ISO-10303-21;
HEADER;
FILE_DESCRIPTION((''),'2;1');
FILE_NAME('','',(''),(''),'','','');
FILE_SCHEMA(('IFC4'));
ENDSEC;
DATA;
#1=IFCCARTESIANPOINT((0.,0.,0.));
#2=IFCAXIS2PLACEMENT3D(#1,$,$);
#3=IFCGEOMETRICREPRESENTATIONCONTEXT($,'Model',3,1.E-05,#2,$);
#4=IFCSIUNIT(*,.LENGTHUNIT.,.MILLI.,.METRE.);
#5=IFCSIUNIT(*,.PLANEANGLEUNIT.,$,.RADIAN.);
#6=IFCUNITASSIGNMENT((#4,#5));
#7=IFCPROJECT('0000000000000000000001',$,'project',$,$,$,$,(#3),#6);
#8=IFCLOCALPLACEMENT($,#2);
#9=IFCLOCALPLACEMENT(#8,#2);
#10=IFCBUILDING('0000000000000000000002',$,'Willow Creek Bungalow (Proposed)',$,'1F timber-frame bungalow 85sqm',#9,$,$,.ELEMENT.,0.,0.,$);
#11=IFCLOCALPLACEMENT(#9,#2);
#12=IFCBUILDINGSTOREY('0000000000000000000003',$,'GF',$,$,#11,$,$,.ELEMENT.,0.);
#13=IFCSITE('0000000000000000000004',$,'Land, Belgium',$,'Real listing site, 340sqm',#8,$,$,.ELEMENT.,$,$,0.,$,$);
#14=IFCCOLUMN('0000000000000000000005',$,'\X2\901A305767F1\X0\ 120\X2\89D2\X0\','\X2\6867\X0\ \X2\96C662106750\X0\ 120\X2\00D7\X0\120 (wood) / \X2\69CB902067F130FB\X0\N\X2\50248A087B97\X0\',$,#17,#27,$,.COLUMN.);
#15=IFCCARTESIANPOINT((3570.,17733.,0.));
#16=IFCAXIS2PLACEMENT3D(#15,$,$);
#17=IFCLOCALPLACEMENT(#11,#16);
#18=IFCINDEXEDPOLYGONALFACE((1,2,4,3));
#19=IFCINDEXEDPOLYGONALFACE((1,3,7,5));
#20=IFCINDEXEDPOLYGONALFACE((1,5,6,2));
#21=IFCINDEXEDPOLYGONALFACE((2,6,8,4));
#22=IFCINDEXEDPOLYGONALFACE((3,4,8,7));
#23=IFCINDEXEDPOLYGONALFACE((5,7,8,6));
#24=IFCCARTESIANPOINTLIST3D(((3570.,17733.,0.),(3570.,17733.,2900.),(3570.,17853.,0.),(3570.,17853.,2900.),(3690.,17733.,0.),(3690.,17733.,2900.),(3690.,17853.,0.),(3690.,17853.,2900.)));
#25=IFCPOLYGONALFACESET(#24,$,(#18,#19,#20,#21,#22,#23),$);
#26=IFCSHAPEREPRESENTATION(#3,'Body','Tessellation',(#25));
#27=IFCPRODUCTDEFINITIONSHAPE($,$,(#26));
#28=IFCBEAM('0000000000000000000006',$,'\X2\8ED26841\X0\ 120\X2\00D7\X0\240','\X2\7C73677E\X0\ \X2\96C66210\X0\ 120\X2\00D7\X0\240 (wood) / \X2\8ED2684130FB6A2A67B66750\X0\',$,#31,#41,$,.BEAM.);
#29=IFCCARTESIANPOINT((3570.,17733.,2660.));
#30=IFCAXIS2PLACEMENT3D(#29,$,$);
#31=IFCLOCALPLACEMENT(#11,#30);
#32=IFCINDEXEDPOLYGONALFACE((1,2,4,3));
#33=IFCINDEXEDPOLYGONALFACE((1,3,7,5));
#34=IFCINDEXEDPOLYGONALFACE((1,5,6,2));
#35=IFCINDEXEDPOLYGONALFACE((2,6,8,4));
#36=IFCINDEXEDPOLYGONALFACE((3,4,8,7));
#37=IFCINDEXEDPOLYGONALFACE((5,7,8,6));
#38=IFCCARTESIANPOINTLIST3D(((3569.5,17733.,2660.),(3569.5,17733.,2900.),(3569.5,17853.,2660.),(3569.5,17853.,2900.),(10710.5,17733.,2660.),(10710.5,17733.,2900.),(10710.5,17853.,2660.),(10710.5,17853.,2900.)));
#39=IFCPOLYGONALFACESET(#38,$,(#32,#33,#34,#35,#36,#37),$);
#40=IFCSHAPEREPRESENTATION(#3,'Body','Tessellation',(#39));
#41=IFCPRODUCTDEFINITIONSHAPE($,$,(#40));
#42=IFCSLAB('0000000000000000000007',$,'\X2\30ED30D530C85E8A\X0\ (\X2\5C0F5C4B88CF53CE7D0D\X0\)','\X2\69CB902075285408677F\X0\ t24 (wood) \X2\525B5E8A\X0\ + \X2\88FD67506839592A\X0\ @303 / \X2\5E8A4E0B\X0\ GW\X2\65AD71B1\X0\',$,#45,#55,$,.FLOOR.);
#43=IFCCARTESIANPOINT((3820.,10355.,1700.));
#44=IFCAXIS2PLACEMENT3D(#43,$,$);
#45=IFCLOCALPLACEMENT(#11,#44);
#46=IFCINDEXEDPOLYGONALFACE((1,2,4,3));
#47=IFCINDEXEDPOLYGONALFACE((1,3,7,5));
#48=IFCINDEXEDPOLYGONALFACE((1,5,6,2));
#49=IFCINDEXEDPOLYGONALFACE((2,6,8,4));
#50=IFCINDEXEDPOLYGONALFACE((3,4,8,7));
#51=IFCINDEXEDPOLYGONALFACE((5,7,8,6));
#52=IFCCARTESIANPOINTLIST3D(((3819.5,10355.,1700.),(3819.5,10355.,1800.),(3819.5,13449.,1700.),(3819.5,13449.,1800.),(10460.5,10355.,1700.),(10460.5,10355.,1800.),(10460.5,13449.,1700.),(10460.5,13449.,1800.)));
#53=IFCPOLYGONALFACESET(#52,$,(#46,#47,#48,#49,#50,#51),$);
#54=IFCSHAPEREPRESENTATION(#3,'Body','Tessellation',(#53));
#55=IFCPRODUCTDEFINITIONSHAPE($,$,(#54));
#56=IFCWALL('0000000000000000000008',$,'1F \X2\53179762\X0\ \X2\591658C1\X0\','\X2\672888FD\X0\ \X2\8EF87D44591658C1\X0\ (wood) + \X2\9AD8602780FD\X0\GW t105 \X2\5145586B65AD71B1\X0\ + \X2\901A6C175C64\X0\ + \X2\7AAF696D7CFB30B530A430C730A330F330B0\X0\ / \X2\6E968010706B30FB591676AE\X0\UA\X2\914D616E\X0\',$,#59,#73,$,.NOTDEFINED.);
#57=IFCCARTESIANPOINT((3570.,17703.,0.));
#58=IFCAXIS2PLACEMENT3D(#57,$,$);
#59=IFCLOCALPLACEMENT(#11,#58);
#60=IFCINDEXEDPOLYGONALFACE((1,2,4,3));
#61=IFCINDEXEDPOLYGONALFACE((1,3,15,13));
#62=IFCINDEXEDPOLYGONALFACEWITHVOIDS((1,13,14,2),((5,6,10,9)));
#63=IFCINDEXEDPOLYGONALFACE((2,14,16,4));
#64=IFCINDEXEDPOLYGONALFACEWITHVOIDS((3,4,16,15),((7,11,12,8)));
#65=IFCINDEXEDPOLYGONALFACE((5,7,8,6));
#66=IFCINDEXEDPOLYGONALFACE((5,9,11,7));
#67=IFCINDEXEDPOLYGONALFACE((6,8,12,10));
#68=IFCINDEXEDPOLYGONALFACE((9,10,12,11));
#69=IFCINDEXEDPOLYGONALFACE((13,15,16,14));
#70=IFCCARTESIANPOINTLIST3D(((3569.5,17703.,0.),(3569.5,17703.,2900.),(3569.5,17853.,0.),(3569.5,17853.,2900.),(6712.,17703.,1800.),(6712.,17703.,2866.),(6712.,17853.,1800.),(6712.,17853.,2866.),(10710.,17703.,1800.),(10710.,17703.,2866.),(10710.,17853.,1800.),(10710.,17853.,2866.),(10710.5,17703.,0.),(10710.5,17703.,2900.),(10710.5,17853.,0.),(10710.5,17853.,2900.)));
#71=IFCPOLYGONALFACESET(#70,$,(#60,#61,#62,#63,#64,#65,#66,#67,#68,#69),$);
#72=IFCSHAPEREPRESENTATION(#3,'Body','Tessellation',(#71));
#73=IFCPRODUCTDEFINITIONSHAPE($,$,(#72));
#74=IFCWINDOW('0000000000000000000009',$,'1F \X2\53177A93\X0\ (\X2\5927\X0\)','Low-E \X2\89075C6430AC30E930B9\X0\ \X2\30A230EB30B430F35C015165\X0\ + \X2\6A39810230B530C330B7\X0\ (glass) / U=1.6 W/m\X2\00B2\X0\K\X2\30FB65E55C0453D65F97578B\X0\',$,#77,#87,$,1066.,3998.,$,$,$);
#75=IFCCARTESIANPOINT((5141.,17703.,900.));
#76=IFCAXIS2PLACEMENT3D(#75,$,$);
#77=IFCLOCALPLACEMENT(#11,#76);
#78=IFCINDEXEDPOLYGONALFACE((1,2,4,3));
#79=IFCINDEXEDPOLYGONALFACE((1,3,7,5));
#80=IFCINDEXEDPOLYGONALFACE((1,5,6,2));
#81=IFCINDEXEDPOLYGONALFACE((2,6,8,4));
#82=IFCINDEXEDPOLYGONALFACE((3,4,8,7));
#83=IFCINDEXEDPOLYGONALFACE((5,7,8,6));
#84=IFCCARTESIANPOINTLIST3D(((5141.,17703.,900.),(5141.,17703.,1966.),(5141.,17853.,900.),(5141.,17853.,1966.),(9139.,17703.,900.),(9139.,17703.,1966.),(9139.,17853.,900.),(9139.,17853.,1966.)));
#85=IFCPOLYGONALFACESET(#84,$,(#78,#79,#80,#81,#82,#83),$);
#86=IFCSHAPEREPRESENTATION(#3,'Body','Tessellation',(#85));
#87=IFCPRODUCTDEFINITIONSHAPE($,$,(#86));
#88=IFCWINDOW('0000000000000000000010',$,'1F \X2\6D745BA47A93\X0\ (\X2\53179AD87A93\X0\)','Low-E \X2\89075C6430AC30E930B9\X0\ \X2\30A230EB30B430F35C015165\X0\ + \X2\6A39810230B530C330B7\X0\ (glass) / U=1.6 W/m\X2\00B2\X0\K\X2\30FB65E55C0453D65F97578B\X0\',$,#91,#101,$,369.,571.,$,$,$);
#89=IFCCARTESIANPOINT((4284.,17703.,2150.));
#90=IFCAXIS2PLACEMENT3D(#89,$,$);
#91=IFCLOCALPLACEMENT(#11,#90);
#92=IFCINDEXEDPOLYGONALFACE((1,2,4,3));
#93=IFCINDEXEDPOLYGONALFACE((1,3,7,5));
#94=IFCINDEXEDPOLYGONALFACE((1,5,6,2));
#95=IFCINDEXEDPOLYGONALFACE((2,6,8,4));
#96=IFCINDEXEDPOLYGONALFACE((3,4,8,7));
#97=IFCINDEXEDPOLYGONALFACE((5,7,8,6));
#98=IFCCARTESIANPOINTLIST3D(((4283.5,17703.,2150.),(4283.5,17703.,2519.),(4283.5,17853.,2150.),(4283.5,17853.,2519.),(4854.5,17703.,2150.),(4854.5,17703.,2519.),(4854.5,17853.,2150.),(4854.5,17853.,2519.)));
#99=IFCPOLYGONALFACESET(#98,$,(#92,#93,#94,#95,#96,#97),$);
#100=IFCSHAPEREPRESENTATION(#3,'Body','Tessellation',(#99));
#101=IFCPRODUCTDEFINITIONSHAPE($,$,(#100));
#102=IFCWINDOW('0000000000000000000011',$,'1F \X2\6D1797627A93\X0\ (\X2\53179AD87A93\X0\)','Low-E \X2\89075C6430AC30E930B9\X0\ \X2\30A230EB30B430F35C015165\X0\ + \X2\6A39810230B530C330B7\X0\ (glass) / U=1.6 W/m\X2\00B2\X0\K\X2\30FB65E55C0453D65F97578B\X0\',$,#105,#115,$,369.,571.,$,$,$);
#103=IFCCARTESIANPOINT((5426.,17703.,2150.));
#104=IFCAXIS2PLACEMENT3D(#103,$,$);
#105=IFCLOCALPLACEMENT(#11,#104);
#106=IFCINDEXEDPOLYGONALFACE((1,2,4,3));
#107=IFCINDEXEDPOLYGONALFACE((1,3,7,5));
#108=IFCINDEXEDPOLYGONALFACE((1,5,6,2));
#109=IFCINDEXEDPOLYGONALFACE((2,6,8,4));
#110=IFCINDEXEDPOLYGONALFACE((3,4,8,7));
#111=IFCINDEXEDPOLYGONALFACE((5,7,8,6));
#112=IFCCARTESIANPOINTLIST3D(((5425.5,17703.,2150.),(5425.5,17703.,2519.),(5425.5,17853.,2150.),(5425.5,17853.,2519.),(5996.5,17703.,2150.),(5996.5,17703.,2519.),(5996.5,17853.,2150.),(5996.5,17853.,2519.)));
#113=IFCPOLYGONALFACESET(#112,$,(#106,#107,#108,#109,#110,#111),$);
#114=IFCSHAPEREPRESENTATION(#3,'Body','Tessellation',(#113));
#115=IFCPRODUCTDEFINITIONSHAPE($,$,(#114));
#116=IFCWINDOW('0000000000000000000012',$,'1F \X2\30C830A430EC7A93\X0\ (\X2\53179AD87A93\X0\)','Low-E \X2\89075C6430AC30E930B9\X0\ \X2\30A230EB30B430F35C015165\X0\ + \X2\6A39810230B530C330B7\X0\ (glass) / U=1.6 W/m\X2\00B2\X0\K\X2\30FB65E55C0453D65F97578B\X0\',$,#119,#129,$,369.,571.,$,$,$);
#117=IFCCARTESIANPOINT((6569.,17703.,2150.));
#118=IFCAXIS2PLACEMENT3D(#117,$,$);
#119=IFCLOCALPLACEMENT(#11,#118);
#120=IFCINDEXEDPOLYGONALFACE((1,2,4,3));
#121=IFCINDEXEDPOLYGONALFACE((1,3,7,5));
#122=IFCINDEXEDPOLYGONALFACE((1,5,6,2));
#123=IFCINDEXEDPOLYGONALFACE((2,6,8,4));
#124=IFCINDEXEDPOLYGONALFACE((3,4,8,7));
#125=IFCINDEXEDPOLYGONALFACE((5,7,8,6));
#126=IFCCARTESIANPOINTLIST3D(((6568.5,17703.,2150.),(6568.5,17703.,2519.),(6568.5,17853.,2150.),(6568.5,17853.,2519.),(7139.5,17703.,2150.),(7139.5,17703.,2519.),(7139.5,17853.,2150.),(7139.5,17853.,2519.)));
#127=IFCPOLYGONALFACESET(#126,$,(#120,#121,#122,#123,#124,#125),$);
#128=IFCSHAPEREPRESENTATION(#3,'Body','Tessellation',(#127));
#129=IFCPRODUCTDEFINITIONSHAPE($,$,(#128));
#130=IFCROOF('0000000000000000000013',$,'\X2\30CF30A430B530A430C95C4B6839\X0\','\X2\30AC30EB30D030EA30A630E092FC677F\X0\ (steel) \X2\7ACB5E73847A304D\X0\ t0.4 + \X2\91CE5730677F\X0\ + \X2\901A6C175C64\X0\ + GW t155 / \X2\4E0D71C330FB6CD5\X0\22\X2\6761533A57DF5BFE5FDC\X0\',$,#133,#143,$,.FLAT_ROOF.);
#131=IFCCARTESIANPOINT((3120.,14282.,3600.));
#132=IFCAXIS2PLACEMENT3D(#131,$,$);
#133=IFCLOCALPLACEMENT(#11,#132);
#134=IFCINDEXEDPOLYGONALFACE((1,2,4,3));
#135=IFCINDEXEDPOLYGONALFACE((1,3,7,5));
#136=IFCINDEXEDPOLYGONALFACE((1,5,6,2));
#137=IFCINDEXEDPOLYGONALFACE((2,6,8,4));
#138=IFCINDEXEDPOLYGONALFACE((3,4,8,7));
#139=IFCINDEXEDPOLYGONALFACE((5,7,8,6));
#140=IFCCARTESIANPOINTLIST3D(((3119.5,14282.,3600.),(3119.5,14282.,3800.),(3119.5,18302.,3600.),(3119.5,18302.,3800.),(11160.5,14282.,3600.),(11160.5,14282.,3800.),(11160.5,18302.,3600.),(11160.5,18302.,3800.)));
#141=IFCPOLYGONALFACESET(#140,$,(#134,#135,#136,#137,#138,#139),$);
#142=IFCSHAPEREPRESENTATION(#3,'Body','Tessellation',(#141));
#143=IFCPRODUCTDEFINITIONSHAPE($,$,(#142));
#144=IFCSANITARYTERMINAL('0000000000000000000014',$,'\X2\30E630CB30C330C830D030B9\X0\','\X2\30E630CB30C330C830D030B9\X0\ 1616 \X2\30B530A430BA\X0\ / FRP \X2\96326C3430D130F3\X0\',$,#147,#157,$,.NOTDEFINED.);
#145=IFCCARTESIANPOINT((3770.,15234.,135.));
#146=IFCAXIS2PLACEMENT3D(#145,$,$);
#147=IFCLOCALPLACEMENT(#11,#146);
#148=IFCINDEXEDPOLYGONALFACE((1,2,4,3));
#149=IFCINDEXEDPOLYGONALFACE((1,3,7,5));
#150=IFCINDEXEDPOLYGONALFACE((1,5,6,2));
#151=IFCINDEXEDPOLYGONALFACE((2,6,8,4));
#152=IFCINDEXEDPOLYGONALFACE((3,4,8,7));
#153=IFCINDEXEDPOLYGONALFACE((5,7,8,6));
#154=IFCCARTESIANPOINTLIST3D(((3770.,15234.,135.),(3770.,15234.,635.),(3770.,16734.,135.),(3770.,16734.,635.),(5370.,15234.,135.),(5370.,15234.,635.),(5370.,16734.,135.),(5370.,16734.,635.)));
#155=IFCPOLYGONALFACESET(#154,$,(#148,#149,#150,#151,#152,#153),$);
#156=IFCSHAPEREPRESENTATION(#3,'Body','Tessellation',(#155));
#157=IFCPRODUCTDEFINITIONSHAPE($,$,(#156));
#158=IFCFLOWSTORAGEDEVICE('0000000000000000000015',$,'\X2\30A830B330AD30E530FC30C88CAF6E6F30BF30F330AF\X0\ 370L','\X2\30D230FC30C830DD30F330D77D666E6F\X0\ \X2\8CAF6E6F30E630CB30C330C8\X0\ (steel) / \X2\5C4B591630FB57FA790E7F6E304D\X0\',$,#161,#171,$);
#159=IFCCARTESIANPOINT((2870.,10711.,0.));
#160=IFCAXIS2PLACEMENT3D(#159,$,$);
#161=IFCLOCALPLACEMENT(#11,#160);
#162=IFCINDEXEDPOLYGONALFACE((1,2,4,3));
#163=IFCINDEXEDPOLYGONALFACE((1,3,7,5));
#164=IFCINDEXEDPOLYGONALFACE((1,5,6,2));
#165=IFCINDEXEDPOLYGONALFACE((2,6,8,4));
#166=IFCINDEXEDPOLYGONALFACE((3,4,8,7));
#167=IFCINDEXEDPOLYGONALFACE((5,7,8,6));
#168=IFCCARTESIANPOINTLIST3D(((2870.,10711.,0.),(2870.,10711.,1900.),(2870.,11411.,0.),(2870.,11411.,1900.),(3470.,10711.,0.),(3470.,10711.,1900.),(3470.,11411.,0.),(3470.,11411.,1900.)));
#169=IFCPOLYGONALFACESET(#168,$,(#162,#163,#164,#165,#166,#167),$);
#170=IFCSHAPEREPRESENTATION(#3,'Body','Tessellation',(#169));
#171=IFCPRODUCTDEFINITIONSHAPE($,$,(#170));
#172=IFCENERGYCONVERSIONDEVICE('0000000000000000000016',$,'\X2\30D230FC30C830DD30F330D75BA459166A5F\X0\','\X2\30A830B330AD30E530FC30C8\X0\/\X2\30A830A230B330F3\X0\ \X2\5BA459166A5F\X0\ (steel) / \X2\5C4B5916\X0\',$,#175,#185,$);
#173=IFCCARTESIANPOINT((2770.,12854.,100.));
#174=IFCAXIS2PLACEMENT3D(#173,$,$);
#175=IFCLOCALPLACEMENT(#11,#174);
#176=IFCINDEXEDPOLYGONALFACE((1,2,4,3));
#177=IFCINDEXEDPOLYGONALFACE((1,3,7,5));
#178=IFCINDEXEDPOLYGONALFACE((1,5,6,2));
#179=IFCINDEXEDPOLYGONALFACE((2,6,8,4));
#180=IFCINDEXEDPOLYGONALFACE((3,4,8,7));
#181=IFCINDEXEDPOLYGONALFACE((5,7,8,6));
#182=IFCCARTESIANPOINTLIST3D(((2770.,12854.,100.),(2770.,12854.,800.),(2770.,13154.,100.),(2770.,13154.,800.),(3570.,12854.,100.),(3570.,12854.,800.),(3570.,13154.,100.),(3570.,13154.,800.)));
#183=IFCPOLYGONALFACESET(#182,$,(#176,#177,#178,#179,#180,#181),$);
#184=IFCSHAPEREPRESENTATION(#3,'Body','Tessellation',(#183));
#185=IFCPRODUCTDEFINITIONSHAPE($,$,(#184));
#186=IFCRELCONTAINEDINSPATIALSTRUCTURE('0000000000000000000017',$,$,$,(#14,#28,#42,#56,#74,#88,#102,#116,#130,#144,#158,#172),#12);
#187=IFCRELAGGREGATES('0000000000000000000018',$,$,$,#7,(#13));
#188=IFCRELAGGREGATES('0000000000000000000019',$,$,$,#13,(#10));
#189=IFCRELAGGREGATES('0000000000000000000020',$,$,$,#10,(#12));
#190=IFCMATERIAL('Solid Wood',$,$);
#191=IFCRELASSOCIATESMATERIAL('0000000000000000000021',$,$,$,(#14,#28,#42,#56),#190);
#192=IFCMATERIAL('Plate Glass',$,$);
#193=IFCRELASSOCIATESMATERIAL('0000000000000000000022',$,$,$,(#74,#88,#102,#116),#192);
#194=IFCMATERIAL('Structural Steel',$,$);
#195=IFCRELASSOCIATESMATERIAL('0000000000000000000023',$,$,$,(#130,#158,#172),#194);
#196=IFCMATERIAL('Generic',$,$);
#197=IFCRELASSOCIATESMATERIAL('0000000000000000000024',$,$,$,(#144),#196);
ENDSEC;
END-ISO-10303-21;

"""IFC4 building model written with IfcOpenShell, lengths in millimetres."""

from ifc_helpers import new_model, si_unit, frame, frame_2d, origin, place, context, project, spatial, rectangle, extrude, material, element, fill, save


model = new_model("IFC4")

# Units and contexts
model_context = context("Model", 3, precision=1e-05, world=origin())
ifc_project = project(units=[si_unit("LENGTHUNIT", "METRE", prefix="MILLI"), si_unit("PLANEANGLEUNIT", "RADIAN")], contexts=[model_context])

# Site, building, storey
site_placement = place(None, origin())
site = spatial("IfcSite", under=ifc_project, at=site_placement, Name="Land, Belgium", ObjectType="Real listing site, 340sqm", CompositionType="ELEMENT", RefElevation=0.0)
building_placement = place(site_placement, origin())
building = spatial("IfcBuilding", under=site, at=building_placement, Name="Willow Creek Bungalow (Proposed)", ObjectType="1F timber-frame bungalow 85sqm", CompositionType="ELEMENT", ElevationOfRefHeight=0.0, ElevationOfTerrain=0.0)
storey_placement = place(building_placement, origin())
storey = spatial("IfcBuildingStorey", under=building, at=storey_placement, Name="GF", CompositionType="ELEMENT", Elevation=0.0)

# Column
ifc_material_1 = material(Name="Solid Wood")
column_1_placement = place(storey_placement, frame((3570.0, 17733.0, 0.0)))
element("IfcColumn", 1, at=column_1_placement, inside=storey, material=ifc_material_1, Name="通し柱 120角", Description="桧 集成材 120×120 (wood) / 構造柱・N値計算", PredefinedType="COLUMN", context=model_context, shape_type="SweptSolid", body=[
    extrude(rectangle(XDim=120.0, YDim=120.0, at=frame_2d((60.0, 60.0))), frame((3570.0, 17733.0, 0.0)), (0.0, 0.0, 1.0), 2900.0),
])

# Beam
beam_1_placement = place(storey_placement, frame((3570.0, 17733.0, 2660.0)))
element("IfcBeam", 2, at=beam_1_placement, inside=storey, material=ifc_material_1, Name="軒桁 120×240", Description="米松 集成 120×240 (wood) / 軒桁・横架材", PredefinedType="BEAM", context=model_context, shape_type="SweptSolid", body=[
    extrude(rectangle(XDim=7141.0, YDim=120.0, at=frame_2d((3570.0, 60.0))), frame((3570.0, 17733.0, 2660.0)), (0.0, 0.0, 1.0), 240.0),
])

# Slab
slab_placement = place(storey_placement, frame((3820.0, 10355.0, 1700.0)))
element("IfcSlab", 3, at=slab_placement, inside=storey, material=ifc_material_1, Name="ロフト床 (小屋裏収納)", Description="構造用合板 t24 (wood) 剛床 + 製材根太 @303 / 床下 GW断熱", PredefinedType="FLOOR", context=model_context, shape_type="SweptSolid", body=[
    extrude(rectangle(XDim=6641.0, YDim=3094.0, at=frame_2d((3320.0, 1547.0))), frame((3820.0, 10355.0, 1700.0)), (0.0, 0.0, 1.0), 100.0),
])

# Wall, openings, windows
wall_1_placement = place(storey_placement, frame((3570.0, 17703.0, 0.0)))
wall_1 = element("IfcWall", 4, at=wall_1_placement, inside=storey, material=ifc_material_1, Name="1F 北面 外壁", Description="木製 軸組外壁 (wood) + 高性能GW t105 充填断熱 + 通気層 + 窯業系サイディング / 準耐火・外皮UA配慮", PredefinedType="NOTDEFINED", context=model_context, shape_type="SweptSolid", body=[
    extrude(rectangle(XDim=7141.0, YDim=150.0, at=frame_2d((3570.0, 75.0))), frame((3570.0, 17703.0, 0.0)), (0.0, 0.0, 1.0), 2900.0),
])
opening_1_placement = place(storey_placement, frame((5141.0, 17703.0, 900.0)))
opening_1 = element("IfcOpeningElement", 5, at=opening_1_placement, cuts=wall_1, PredefinedType="NOTDEFINED", context=model_context, shape_type="SweptSolid", body=[
    extrude(rectangle(XDim=3998.0, YDim=150.0, at=frame_2d((1999.0, 75.0))), frame((5141.0, 17703.0, 900.0)), (0.0, 0.0, 1.0), 1066.0),
])
opening_2_placement = place(storey_placement, frame((4284.0, 17703.0, 2150.0)))
opening_2 = element("IfcOpeningElement", 6, at=opening_2_placement, cuts=wall_1, PredefinedType="NOTDEFINED", context=model_context, shape_type="SweptSolid", body=[
    extrude(rectangle(XDim=571.0, YDim=150.0, at=frame_2d((285.0, 75.0))), frame((4284.0, 17703.0, 2150.0)), (0.0, 0.0, 1.0), 369.0),
])
opening_3_placement = place(storey_placement, frame((5426.0, 17703.0, 2150.0)))
opening_3 = element("IfcOpeningElement", 7, at=opening_3_placement, cuts=wall_1, PredefinedType="NOTDEFINED", context=model_context, shape_type="SweptSolid", body=[
    extrude(rectangle(XDim=571.0, YDim=150.0, at=frame_2d((285.0, 75.0))), frame((5426.0, 17703.0, 2150.0)), (0.0, 0.0, 1.0), 369.0),
])
opening_4_placement = place(storey_placement, frame((6569.0, 17703.0, 2150.0)))
opening_4 = element("IfcOpeningElement", 8, at=opening_4_placement, cuts=wall_1, PredefinedType="NOTDEFINED", context=model_context, shape_type="SweptSolid", body=[
    extrude(rectangle(XDim=571.0, YDim=150.0, at=frame_2d((285.0, 75.0))), frame((6569.0, 17703.0, 2150.0)), (0.0, 0.0, 1.0), 369.0),
])
ifc_material_2 = material(Name="Plate Glass")
window_1_placement = place(storey_placement, frame((5141.0, 17703.0, 900.0)))
window_1 = element("IfcWindow", 9, at=window_1_placement, inside=storey, material=ifc_material_2, Name="1F 北窓 (大)", Description="Low-E 複層ガラス アルゴン封入 + 樹脂サッシ (glass) / U=1.6 W/m²K・日射取得型", OverallHeight=1066.0, OverallWidth=3998.0, context=model_context, shape_type="SweptSolid", body=[
    extrude(rectangle(XDim=3998.0, YDim=150.0, at=frame_2d((1999.0, 75.0))), frame((5141.0, 17703.0, 900.0)), (0.0, 0.0, 1.0), 1066.0),
])
fill(opening_1, window_1)
window_2_placement = place(storey_placement, frame((4284.0, 17703.0, 2150.0)))
window_2 = element("IfcWindow", 10, at=window_2_placement, inside=storey, material=ifc_material_2, Name="1F 浴室窓 (北高窓)", Description="Low-E 複層ガラス アルゴン封入 + 樹脂サッシ (glass) / U=1.6 W/m²K・日射取得型", OverallHeight=369.0, OverallWidth=571.0, context=model_context, shape_type="SweptSolid", body=[
    extrude(rectangle(XDim=571.0, YDim=150.0, at=frame_2d((285.0, 75.0))), frame((4284.0, 17703.0, 2150.0)), (0.0, 0.0, 1.0), 369.0),
])
fill(opening_2, window_2)
window_3_placement = place(storey_placement, frame((5426.0, 17703.0, 2150.0)))
window_3 = element("IfcWindow", 11, at=window_3_placement, inside=storey, material=ifc_material_2, Name="1F 洗面窓 (北高窓)", Description="Low-E 複層ガラス アルゴン封入 + 樹脂サッシ (glass) / U=1.6 W/m²K・日射取得型", OverallHeight=369.0, OverallWidth=571.0, context=model_context, shape_type="SweptSolid", body=[
    extrude(rectangle(XDim=571.0, YDim=150.0, at=frame_2d((285.0, 75.0))), frame((5426.0, 17703.0, 2150.0)), (0.0, 0.0, 1.0), 369.0),
])
fill(opening_3, window_3)
window_4_placement = place(storey_placement, frame((6569.0, 17703.0, 2150.0)))
window_4 = element("IfcWindow", 12, at=window_4_placement, inside=storey, material=ifc_material_2, Name="1F トイレ窓 (北高窓)", Description="Low-E 複層ガラス アルゴン封入 + 樹脂サッシ (glass) / U=1.6 W/m²K・日射取得型", OverallHeight=369.0, OverallWidth=571.0, context=model_context, shape_type="SweptSolid", body=[
    extrude(rectangle(XDim=571.0, YDim=150.0, at=frame_2d((285.0, 75.0))), frame((6569.0, 17703.0, 2150.0)), (0.0, 0.0, 1.0), 369.0),
])
fill(opening_4, window_4)

# Roof
ifc_material_3 = material(Name="Structural Steel")
roof_placement = place(storey_placement, frame((3120.0, 14282.0, 3600.0)))
element("IfcRoof", 13, at=roof_placement, inside=storey, material=ifc_material_3, Name="ハイサイド屋根", Description="ガルバリウム鋼板 (steel) 立平葺き t0.4 + 野地板 + 通気層 + GW t155 / 不燃・法22条区域対応", PredefinedType="FLAT_ROOF", context=model_context, shape_type="SweptSolid", body=[
    extrude(rectangle(XDim=8041.0, YDim=4020.0, at=frame_2d((4020.0, 2010.0))), frame((3120.0, 14282.0, 3600.0)), (0.0, 0.0, 1.0), 200.0),
])

# Sanitary terminal
ifc_material_4 = material(Name="Generic")
sanitary_terminal_placement = place(storey_placement, frame((3770.0, 15234.0, 135.0)))
element("IfcSanitaryTerminal", 14, at=sanitary_terminal_placement, inside=storey, material=ifc_material_4, Name="ユニットバス", Description="ユニットバス 1616 サイズ / FRP 防水パン", PredefinedType="NOTDEFINED", context=model_context, shape_type="SweptSolid", body=[
    extrude(rectangle(XDim=1600.0, YDim=1500.0, at=frame_2d((800.0, 750.0))), frame((3770.0, 15234.0, 135.0)), (0.0, 0.0, 1.0), 500.0),
])

# Flow storage device
flow_storage_device_placement = place(storey_placement, frame((2870.0, 10711.0, 0.0)))
element("IfcFlowStorageDevice", 15, at=flow_storage_device_placement, inside=storey, material=ifc_material_3, Name="エコキュート貯湯タンク 370L", Description="ヒートポンプ給湯 貯湯ユニット (steel) / 屋外・基礎置き", context=model_context, shape_type="SweptSolid", body=[
    extrude(rectangle(XDim=600.0, YDim=700.0, at=frame_2d((300.0, 350.0))), frame((2870.0, 10711.0, 0.0)), (0.0, 0.0, 1.0), 1900.0),
])

# Energy conversion device
energy_conversion_device_placement = place(storey_placement, frame((2770.0, 12854.0, 100.0)))
element("IfcEnergyConversionDevice", 16, at=energy_conversion_device_placement, inside=storey, material=ifc_material_3, Name="ヒートポンプ室外機", Description="エコキュート/エアコン 室外機 (steel) / 屋外", context=model_context, shape_type="SweptSolid", body=[
    extrude(rectangle(XDim=800.0, YDim=300.0, at=frame_2d((400.0, 150.0))), frame((2770.0, 12854.0, 100.0)), (0.0, 0.0, 1.0), 700.0),
])

save(model, "model.ifc")
